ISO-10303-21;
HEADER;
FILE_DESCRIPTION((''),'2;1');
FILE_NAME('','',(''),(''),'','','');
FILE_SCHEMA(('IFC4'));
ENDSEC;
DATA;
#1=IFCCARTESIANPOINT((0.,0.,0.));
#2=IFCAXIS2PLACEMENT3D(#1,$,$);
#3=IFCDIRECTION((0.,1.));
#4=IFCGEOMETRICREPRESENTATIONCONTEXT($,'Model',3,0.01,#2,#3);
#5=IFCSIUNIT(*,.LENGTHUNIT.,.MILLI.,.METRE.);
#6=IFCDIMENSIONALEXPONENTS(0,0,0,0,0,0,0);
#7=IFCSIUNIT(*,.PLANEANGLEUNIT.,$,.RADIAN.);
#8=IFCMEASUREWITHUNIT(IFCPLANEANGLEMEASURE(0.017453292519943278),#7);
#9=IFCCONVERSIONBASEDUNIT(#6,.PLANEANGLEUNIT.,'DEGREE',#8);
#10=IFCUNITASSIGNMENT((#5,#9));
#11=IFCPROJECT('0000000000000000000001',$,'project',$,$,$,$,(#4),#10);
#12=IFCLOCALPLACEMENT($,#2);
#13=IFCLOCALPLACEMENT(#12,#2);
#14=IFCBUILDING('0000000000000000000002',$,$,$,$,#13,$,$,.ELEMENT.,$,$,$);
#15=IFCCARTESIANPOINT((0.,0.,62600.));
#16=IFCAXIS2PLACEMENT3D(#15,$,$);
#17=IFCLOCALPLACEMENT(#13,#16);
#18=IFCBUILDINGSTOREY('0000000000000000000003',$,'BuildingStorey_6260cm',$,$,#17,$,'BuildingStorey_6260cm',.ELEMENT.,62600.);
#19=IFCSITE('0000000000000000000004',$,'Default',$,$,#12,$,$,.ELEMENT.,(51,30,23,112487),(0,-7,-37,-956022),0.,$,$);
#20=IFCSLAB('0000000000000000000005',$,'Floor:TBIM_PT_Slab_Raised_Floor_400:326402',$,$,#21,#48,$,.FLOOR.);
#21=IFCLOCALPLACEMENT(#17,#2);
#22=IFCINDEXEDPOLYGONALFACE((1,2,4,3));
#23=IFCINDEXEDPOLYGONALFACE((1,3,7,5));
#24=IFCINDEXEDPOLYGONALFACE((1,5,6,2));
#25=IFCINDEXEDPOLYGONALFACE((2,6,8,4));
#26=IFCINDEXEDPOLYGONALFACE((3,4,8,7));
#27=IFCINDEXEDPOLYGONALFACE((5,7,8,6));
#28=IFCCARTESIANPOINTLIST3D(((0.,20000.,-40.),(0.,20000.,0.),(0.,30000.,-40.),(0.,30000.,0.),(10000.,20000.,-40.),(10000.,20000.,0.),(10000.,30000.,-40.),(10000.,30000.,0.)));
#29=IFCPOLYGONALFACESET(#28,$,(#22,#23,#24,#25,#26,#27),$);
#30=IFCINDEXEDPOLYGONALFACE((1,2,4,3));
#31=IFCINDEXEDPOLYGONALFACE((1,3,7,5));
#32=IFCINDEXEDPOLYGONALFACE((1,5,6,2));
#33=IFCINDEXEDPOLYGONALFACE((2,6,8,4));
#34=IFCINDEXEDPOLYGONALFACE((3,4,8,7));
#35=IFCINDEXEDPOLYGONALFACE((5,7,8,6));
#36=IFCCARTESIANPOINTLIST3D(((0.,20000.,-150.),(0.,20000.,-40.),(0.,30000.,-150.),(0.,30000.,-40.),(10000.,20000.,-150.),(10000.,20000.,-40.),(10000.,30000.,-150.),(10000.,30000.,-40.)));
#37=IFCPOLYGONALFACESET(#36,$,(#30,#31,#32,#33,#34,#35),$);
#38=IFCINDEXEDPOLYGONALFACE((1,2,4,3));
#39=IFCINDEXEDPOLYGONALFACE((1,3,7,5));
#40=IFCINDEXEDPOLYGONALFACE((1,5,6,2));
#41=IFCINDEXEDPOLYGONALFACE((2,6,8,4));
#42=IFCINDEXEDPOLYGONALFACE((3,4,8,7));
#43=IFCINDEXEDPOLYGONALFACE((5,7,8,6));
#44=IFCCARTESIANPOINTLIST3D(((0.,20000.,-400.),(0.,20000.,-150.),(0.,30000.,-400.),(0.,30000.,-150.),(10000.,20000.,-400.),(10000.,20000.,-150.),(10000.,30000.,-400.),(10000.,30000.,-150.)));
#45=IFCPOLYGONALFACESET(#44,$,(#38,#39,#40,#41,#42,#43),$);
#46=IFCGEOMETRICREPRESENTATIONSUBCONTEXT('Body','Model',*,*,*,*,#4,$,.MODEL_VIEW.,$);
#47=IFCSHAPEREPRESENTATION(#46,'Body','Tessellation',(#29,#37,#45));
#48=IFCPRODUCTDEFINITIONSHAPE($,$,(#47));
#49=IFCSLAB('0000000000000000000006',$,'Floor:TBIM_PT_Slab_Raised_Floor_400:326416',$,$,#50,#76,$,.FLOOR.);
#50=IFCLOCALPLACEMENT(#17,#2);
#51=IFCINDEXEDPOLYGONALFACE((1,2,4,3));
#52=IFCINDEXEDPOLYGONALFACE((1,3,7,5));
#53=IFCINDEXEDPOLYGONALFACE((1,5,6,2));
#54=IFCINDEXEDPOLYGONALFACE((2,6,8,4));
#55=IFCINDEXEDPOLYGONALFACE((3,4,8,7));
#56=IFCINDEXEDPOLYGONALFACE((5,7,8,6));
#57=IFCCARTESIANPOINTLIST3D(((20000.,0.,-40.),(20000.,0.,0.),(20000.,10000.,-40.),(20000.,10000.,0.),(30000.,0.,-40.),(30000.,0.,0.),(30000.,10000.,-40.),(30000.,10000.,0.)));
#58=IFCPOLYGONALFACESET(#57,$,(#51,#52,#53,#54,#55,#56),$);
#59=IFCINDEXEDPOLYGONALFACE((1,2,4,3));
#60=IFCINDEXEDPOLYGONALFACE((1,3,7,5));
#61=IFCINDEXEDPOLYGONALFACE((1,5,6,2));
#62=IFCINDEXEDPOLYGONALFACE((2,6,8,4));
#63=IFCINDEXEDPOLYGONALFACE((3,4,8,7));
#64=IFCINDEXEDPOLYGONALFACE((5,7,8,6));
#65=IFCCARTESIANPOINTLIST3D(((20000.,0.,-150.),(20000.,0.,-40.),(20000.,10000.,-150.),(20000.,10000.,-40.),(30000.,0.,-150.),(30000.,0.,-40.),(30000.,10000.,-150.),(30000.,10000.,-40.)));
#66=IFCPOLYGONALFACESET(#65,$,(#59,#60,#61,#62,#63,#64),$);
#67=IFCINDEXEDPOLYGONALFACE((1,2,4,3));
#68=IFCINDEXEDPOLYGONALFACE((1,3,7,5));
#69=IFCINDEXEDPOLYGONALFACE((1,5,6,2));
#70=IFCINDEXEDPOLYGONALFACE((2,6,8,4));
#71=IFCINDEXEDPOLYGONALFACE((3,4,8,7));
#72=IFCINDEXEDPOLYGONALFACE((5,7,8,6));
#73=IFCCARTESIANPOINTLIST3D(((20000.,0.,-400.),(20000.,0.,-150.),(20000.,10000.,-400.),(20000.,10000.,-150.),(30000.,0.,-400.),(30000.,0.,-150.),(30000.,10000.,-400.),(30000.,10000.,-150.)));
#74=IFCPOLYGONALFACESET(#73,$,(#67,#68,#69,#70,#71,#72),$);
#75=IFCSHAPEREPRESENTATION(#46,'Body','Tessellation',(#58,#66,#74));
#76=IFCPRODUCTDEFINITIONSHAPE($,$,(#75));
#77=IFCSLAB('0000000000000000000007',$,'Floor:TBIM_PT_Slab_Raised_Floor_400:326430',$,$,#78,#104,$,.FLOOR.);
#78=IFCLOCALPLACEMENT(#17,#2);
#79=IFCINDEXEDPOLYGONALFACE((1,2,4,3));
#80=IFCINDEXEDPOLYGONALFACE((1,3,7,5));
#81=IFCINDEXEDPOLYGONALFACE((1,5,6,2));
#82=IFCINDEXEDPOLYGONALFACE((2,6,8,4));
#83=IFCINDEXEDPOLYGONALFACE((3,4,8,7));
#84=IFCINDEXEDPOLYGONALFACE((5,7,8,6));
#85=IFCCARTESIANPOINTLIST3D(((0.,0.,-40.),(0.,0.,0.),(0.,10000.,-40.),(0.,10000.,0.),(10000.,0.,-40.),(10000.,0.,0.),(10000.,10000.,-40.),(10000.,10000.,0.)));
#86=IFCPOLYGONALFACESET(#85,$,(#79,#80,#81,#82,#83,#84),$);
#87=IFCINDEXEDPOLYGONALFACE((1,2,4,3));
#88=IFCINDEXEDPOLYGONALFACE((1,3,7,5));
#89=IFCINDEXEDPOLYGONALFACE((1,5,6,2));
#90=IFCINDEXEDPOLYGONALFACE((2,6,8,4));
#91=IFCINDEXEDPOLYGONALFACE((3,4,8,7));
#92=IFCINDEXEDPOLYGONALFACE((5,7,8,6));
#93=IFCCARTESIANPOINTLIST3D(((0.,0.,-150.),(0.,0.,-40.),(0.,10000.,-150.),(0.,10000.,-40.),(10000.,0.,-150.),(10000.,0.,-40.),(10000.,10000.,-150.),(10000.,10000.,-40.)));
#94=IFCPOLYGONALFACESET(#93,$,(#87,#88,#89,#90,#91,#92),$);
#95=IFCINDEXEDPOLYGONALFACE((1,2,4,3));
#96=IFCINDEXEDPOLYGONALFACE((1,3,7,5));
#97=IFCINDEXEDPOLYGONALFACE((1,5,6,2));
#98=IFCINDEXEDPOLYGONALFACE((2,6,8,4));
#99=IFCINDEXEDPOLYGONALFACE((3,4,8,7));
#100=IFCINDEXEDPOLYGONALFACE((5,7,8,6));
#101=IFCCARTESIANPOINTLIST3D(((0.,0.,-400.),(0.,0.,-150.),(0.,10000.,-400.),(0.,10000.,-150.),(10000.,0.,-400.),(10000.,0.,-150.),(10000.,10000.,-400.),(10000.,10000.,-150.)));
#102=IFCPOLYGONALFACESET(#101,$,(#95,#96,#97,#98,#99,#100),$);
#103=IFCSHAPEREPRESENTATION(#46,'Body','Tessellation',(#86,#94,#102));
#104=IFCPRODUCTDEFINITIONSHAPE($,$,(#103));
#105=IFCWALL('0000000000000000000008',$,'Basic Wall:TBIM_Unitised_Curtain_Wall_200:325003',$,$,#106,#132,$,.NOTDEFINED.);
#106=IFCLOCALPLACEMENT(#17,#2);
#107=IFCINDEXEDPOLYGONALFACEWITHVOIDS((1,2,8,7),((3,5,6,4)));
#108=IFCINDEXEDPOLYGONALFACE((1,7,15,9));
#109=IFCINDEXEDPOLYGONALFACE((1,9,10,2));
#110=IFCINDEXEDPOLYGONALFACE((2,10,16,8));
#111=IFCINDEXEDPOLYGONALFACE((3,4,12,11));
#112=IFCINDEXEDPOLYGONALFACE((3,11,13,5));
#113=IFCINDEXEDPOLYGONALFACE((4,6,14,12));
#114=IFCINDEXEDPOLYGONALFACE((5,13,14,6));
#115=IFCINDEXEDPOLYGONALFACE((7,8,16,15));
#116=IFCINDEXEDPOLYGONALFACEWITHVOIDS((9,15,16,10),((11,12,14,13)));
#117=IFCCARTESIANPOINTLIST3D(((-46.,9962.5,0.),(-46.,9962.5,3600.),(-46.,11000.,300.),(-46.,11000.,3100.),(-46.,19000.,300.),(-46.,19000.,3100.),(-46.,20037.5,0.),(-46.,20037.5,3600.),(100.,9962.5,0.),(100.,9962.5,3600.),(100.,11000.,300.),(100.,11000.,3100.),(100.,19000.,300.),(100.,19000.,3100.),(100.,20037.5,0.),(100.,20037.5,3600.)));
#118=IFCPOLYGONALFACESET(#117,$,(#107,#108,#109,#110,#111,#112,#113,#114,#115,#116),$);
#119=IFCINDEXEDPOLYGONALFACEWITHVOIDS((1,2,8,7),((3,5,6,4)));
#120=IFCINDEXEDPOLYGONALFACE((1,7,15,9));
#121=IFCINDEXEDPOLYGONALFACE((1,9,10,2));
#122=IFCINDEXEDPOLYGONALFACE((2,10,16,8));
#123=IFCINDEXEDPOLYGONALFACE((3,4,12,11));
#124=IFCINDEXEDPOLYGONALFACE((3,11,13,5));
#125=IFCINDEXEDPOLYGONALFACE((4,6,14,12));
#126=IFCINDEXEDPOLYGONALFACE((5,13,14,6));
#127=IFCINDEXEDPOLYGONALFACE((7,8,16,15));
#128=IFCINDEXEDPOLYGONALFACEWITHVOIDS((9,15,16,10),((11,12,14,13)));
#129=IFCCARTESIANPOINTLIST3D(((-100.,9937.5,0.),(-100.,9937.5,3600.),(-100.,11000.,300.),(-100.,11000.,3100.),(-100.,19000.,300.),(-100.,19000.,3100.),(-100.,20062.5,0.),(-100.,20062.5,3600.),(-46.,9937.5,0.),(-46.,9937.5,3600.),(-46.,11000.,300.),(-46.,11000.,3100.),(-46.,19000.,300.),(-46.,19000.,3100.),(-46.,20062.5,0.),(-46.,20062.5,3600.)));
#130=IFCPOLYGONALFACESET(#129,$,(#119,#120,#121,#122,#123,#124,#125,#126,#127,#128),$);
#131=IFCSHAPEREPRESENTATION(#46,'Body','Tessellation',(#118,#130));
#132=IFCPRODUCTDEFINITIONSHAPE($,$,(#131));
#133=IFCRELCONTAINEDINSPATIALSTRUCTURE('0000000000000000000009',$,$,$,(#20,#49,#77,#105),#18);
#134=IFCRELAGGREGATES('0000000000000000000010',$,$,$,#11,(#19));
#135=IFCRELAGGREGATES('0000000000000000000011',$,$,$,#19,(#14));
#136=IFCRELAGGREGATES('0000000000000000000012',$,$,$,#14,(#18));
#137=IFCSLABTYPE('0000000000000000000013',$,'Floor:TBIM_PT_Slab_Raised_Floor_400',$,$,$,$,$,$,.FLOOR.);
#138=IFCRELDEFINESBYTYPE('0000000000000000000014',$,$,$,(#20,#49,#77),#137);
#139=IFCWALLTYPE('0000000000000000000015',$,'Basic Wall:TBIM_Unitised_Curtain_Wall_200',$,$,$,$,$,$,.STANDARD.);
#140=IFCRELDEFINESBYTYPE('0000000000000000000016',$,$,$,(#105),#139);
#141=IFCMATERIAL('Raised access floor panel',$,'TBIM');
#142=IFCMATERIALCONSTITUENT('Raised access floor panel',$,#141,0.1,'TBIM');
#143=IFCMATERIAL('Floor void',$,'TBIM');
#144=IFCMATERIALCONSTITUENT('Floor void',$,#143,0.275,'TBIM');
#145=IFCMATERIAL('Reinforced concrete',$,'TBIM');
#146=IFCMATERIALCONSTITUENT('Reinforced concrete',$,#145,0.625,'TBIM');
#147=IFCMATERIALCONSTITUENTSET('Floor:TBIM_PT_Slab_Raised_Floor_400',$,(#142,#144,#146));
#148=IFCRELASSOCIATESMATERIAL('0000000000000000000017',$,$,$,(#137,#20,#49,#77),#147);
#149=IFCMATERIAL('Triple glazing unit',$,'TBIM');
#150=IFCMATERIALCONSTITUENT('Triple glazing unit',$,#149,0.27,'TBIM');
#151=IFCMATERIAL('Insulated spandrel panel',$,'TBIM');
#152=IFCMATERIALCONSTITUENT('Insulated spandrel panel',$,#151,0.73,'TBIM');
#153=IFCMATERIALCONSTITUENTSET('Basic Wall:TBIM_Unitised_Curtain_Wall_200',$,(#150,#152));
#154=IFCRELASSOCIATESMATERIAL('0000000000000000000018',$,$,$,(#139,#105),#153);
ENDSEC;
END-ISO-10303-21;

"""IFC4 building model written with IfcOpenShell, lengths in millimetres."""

from ifc_helpers import new_model, entity, si_unit, converted_unit, direction, frame, origin, place, context, subcontext, project, spatial, indexed_curve, outline, extrude, material, constituent, constituent_set, type_object, element, save


model = new_model("IFC4")

# Units and contexts
model_context = context("Model", 3, precision=0.01, world=origin(), true_north=direction((0.0, 1.0)))
body_context = subcontext(model_context, "Body", "Model", "MODEL_VIEW")
ifc_project = project(units=[si_unit("LENGTHUNIT", "METRE", prefix="MILLI"), converted_unit("PLANEANGLEUNIT", "DEGREE", entity("IfcPlaneAngleMeasure", 0.017453292519943278), si_unit("PLANEANGLEUNIT", "RADIAN"), dimensions=[0, 0, 0, 0, 0, 0, 0])], contexts=[model_context])

# Site, building, storey
site_placement = place(None, origin())
site = spatial("IfcSite", under=ifc_project, at=site_placement, Name="Default", CompositionType="ELEMENT", RefLatitude=(51, 30, 23, 112487), RefLongitude=(0, -7, -37, -956022), RefElevation=0.0)
building_placement = place(site_placement, origin())
building = spatial("IfcBuilding", under=site, at=building_placement, CompositionType="ELEMENT")
storey_placement = place(building_placement, frame((0.0, 0.0, 62600.0)))
storey = spatial("IfcBuildingStorey", under=building, at=storey_placement, Name="BuildingStorey_6260cm", LongName="BuildingStorey_6260cm", CompositionType="ELEMENT", Elevation=62600.0)

# Slabs
ifc_material_1 = material(Name="Raised access floor panel", Category="TBIM")
ifc_constituent_1 = constituent(ifc_material_1, Name="Raised access floor panel", Category="TBIM", fraction=0.1)
ifc_material_2 = material(Name="Floor void", Category="TBIM")
ifc_constituent_2 = constituent(ifc_material_2, Name="Floor void", Category="TBIM", fraction=0.275)
ifc_material_3 = material(Name="Reinforced concrete", Category="TBIM")
ifc_constituent_3 = constituent(ifc_material_3, Name="Reinforced concrete", Category="TBIM", fraction=0.625)
ifc_constituent_set_1 = constituent_set(constituents=[ifc_constituent_1, ifc_constituent_2, ifc_constituent_3], Name="Floor:TBIM_PT_Slab_Raised_Floor_400")
slab_type = type_object("IfcSlabType", Name="Floor:TBIM_PT_Slab_Raised_Floor_400", PredefinedType="FLOOR", material=ifc_constituent_set_1)
slab_1_placement = place(storey_placement, origin())
element("IfcSlab", 1, at=slab_1_placement, inside=storey, type_object=slab_type, material=ifc_constituent_set_1, Name="Floor:TBIM_PT_Slab_Raised_Floor_400:326402", PredefinedType="FLOOR", context=body_context, shape_type="SweptSolid", body=[
    extrude(outline(indexed_curve([(-5000.0, -5000.0), (5000.0, -5000.0), (5000.0, 5000.0), (-5000.0, 5000.0), (-5000.0, -5000.0)], self_intersect=False)), frame((5000.0, 25000.0, -40.0), z_axis=(0.0, 0.0, 1.0), x_axis=(-1.0, 0.0, 0.0)), (0.0, 0.0, 1.0), 40.0),
    extrude(outline(indexed_curve([(-5000.0, -5000.0), (5000.0, -5000.0), (5000.0, 5000.0), (-5000.0, 5000.0), (-5000.0, -5000.0)], self_intersect=False)), frame((5000.0, 25000.0, -150.0), z_axis=(0.0, 0.0, 1.0), x_axis=(-1.0, 0.0, 0.0)), (0.0, 0.0, 1.0), 110.0),
    extrude(outline(indexed_curve([(-5000.0, -5000.0), (5000.0, -5000.0), (5000.0, 5000.0), (-5000.0, 5000.0), (-5000.0, -5000.0)], self_intersect=False)), frame((5000.0, 25000.0, -400.0), z_axis=(0.0, 0.0, 1.0), x_axis=(-1.0, 0.0, 0.0)), (0.0, 0.0, 1.0), 250.0),
])
slab_2_placement = place(storey_placement, origin())
element("IfcSlab", 2, at=slab_2_placement, inside=storey, type_object=slab_type, material=ifc_constituent_set_1, Name="Floor:TBIM_PT_Slab_Raised_Floor_400:326416", PredefinedType="FLOOR", context=body_context, shape_type="SweptSolid", body=[
    extrude(outline(indexed_curve([(-5000.0, -5000.0), (5000.0, -5000.0), (5000.0, 5000.0), (-5000.0, 5000.0), (-5000.0, -5000.0)], self_intersect=False)), frame((25000.0, 5000.0, -40.0), z_axis=(0.0, 0.0, 1.0), x_axis=(-1.0, 0.0, 0.0)), (0.0, 0.0, 1.0), 40.0),
    extrude(outline(indexed_curve([(-5000.0, -5000.0), (5000.0, -5000.0), (5000.0, 5000.0), (-5000.0, 5000.0), (-5000.0, -5000.0)], self_intersect=False)), frame((25000.0, 5000.0, -150.0), z_axis=(0.0, 0.0, 1.0), x_axis=(-1.0, 0.0, 0.0)), (0.0, 0.0, 1.0), 110.0),
    extrude(outline(indexed_curve([(-5000.0, -5000.0), (5000.0, -5000.0), (5000.0, 5000.0), (-5000.0, 5000.0), (-5000.0, -5000.0)], self_intersect=False)), frame((25000.0, 5000.0, -400.0), z_axis=(0.0, 0.0, 1.0), x_axis=(-1.0, 0.0, 0.0)), (0.0, 0.0, 1.0), 250.0),
])
slab_3_placement = place(storey_placement, origin())
element("IfcSlab", 3, at=slab_3_placement, inside=storey, type_object=slab_type, material=ifc_constituent_set_1, Name="Floor:TBIM_PT_Slab_Raised_Floor_400:326430", PredefinedType="FLOOR", context=body_context, shape_type="SweptSolid", body=[
    extrude(outline(indexed_curve([(-5000.0, -5000.0), (5000.0, -5000.0), (5000.0, 5000.0), (-5000.0, 5000.0), (-5000.0, -5000.0)], self_intersect=False)), frame((5000.0, 5000.0, -40.0), z_axis=(0.0, 0.0, 1.0), x_axis=(-1.0, 0.0, 0.0)), (0.0, 0.0, 1.0), 40.0),
    extrude(outline(indexed_curve([(-5000.0, -5000.0), (5000.0, -5000.0), (5000.0, 5000.0), (-5000.0, 5000.0), (-5000.0, -5000.0)], self_intersect=False)), frame((5000.0, 5000.0, -150.0), z_axis=(0.0, 0.0, 1.0), x_axis=(-1.0, 0.0, 0.0)), (0.0, 0.0, 1.0), 110.0),
    extrude(outline(indexed_curve([(-5000.0, -5000.0), (5000.0, -5000.0), (5000.0, 5000.0), (-5000.0, 5000.0), (-5000.0, -5000.0)], self_intersect=False)), frame((5000.0, 5000.0, -400.0), z_axis=(0.0, 0.0, 1.0), x_axis=(-1.0, 0.0, 0.0)), (0.0, 0.0, 1.0), 250.0),
])

# Wall, opening
ifc_material_4 = material(Name="Triple glazing unit", Category="TBIM")
ifc_constituent_4 = constituent(ifc_material_4, Name="Triple glazing unit", Category="TBIM", fraction=0.27)
ifc_material_5 = material(Name="Insulated spandrel panel", Category="TBIM")
ifc_constituent_5 = constituent(ifc_material_5, Name="Insulated spandrel panel", Category="TBIM", fraction=0.73)
ifc_constituent_set_2 = constituent_set(constituents=[ifc_constituent_4, ifc_constituent_5], Name="Basic Wall:TBIM_Unitised_Curtain_Wall_200")
wall_type = type_object("IfcWallType", Name="Basic Wall:TBIM_Unitised_Curtain_Wall_200", PredefinedType="STANDARD", material=ifc_constituent_set_2)
wall_1_placement = place(storey_placement, frame((0.0, 9937.5, 0.0), z_axis=(0.0, 0.0, 1.0), x_axis=(0.0, 1.0, 0.0)))
wall_1 = element("IfcWall", 4, at=wall_1_placement, inside=storey, type_object=wall_type, material=ifc_constituent_set_2, Name="Basic Wall:TBIM_Unitised_Curtain_Wall_200:325003", PredefinedType="NOTDEFINED", context=body_context, shape_type="SweptSolid", body=[
    extrude(outline(indexed_curve([(-1800.0, -5037.5), (1800.0, -5037.5), (1800.0, 5037.5), (-1800.0, 5037.5), (-1800.0, -5037.5)], self_intersect=False), holes=[indexed_curve([(1300.0, 4000.0), (1300.0, -4000.0), (-1500.0, -4000.0), (-1500.0, 4000.0), (1300.0, 4000.0)], self_intersect=False)]), frame((5062.5, 46.0, 1800.0), z_axis=(0.0, -1.0, 0.0), x_axis=(0.0, 0.0, 1.0)), (0.0, 0.0, 1.0), 146.0),
    extrude(outline(indexed_curve([(-5062.5, -1800.0), (5062.5, -1800.0), (5062.5, 1800.0), (-5062.5, 1800.0), (-5062.5, -1800.0)], self_intersect=False), holes=[indexed_curve([(-4000.0, 1300.0), (4000.0, 1300.0), (4000.0, -1500.0), (-4000.0, -1500.0), (-4000.0, 1300.0)], self_intersect=False)]), frame((5062.5, 100.0, 1800.0), z_axis=(0.0, -1.0, 0.0), x_axis=(1.0, 0.0, 0.0)), (0.0, 0.0, 1.0), 54.0),
])
opening_1_placement = place(wall_1_placement, frame((1062.5, -100.0, 300.0)))
element("IfcOpeningElement", 5, at=opening_1_placement, cuts=wall_1, PredefinedType="OPENING", context=body_context, shape_type="SweptSolid", body=[
    extrude(outline(indexed_curve([(2800.0, 0.0), (2800.0, 8000.0), (0.0, 8000.0), (0.0, 0.0), (2800.0, 0.0)], self_intersect=False)), frame((0.0, 0.0, 0.0), z_axis=(0.0, 1.0, 0.0), x_axis=(0.0, 0.0, 1.0)), (0.0, 0.0, 1.0), 200.0),
])

save(model, "model.ifc")
